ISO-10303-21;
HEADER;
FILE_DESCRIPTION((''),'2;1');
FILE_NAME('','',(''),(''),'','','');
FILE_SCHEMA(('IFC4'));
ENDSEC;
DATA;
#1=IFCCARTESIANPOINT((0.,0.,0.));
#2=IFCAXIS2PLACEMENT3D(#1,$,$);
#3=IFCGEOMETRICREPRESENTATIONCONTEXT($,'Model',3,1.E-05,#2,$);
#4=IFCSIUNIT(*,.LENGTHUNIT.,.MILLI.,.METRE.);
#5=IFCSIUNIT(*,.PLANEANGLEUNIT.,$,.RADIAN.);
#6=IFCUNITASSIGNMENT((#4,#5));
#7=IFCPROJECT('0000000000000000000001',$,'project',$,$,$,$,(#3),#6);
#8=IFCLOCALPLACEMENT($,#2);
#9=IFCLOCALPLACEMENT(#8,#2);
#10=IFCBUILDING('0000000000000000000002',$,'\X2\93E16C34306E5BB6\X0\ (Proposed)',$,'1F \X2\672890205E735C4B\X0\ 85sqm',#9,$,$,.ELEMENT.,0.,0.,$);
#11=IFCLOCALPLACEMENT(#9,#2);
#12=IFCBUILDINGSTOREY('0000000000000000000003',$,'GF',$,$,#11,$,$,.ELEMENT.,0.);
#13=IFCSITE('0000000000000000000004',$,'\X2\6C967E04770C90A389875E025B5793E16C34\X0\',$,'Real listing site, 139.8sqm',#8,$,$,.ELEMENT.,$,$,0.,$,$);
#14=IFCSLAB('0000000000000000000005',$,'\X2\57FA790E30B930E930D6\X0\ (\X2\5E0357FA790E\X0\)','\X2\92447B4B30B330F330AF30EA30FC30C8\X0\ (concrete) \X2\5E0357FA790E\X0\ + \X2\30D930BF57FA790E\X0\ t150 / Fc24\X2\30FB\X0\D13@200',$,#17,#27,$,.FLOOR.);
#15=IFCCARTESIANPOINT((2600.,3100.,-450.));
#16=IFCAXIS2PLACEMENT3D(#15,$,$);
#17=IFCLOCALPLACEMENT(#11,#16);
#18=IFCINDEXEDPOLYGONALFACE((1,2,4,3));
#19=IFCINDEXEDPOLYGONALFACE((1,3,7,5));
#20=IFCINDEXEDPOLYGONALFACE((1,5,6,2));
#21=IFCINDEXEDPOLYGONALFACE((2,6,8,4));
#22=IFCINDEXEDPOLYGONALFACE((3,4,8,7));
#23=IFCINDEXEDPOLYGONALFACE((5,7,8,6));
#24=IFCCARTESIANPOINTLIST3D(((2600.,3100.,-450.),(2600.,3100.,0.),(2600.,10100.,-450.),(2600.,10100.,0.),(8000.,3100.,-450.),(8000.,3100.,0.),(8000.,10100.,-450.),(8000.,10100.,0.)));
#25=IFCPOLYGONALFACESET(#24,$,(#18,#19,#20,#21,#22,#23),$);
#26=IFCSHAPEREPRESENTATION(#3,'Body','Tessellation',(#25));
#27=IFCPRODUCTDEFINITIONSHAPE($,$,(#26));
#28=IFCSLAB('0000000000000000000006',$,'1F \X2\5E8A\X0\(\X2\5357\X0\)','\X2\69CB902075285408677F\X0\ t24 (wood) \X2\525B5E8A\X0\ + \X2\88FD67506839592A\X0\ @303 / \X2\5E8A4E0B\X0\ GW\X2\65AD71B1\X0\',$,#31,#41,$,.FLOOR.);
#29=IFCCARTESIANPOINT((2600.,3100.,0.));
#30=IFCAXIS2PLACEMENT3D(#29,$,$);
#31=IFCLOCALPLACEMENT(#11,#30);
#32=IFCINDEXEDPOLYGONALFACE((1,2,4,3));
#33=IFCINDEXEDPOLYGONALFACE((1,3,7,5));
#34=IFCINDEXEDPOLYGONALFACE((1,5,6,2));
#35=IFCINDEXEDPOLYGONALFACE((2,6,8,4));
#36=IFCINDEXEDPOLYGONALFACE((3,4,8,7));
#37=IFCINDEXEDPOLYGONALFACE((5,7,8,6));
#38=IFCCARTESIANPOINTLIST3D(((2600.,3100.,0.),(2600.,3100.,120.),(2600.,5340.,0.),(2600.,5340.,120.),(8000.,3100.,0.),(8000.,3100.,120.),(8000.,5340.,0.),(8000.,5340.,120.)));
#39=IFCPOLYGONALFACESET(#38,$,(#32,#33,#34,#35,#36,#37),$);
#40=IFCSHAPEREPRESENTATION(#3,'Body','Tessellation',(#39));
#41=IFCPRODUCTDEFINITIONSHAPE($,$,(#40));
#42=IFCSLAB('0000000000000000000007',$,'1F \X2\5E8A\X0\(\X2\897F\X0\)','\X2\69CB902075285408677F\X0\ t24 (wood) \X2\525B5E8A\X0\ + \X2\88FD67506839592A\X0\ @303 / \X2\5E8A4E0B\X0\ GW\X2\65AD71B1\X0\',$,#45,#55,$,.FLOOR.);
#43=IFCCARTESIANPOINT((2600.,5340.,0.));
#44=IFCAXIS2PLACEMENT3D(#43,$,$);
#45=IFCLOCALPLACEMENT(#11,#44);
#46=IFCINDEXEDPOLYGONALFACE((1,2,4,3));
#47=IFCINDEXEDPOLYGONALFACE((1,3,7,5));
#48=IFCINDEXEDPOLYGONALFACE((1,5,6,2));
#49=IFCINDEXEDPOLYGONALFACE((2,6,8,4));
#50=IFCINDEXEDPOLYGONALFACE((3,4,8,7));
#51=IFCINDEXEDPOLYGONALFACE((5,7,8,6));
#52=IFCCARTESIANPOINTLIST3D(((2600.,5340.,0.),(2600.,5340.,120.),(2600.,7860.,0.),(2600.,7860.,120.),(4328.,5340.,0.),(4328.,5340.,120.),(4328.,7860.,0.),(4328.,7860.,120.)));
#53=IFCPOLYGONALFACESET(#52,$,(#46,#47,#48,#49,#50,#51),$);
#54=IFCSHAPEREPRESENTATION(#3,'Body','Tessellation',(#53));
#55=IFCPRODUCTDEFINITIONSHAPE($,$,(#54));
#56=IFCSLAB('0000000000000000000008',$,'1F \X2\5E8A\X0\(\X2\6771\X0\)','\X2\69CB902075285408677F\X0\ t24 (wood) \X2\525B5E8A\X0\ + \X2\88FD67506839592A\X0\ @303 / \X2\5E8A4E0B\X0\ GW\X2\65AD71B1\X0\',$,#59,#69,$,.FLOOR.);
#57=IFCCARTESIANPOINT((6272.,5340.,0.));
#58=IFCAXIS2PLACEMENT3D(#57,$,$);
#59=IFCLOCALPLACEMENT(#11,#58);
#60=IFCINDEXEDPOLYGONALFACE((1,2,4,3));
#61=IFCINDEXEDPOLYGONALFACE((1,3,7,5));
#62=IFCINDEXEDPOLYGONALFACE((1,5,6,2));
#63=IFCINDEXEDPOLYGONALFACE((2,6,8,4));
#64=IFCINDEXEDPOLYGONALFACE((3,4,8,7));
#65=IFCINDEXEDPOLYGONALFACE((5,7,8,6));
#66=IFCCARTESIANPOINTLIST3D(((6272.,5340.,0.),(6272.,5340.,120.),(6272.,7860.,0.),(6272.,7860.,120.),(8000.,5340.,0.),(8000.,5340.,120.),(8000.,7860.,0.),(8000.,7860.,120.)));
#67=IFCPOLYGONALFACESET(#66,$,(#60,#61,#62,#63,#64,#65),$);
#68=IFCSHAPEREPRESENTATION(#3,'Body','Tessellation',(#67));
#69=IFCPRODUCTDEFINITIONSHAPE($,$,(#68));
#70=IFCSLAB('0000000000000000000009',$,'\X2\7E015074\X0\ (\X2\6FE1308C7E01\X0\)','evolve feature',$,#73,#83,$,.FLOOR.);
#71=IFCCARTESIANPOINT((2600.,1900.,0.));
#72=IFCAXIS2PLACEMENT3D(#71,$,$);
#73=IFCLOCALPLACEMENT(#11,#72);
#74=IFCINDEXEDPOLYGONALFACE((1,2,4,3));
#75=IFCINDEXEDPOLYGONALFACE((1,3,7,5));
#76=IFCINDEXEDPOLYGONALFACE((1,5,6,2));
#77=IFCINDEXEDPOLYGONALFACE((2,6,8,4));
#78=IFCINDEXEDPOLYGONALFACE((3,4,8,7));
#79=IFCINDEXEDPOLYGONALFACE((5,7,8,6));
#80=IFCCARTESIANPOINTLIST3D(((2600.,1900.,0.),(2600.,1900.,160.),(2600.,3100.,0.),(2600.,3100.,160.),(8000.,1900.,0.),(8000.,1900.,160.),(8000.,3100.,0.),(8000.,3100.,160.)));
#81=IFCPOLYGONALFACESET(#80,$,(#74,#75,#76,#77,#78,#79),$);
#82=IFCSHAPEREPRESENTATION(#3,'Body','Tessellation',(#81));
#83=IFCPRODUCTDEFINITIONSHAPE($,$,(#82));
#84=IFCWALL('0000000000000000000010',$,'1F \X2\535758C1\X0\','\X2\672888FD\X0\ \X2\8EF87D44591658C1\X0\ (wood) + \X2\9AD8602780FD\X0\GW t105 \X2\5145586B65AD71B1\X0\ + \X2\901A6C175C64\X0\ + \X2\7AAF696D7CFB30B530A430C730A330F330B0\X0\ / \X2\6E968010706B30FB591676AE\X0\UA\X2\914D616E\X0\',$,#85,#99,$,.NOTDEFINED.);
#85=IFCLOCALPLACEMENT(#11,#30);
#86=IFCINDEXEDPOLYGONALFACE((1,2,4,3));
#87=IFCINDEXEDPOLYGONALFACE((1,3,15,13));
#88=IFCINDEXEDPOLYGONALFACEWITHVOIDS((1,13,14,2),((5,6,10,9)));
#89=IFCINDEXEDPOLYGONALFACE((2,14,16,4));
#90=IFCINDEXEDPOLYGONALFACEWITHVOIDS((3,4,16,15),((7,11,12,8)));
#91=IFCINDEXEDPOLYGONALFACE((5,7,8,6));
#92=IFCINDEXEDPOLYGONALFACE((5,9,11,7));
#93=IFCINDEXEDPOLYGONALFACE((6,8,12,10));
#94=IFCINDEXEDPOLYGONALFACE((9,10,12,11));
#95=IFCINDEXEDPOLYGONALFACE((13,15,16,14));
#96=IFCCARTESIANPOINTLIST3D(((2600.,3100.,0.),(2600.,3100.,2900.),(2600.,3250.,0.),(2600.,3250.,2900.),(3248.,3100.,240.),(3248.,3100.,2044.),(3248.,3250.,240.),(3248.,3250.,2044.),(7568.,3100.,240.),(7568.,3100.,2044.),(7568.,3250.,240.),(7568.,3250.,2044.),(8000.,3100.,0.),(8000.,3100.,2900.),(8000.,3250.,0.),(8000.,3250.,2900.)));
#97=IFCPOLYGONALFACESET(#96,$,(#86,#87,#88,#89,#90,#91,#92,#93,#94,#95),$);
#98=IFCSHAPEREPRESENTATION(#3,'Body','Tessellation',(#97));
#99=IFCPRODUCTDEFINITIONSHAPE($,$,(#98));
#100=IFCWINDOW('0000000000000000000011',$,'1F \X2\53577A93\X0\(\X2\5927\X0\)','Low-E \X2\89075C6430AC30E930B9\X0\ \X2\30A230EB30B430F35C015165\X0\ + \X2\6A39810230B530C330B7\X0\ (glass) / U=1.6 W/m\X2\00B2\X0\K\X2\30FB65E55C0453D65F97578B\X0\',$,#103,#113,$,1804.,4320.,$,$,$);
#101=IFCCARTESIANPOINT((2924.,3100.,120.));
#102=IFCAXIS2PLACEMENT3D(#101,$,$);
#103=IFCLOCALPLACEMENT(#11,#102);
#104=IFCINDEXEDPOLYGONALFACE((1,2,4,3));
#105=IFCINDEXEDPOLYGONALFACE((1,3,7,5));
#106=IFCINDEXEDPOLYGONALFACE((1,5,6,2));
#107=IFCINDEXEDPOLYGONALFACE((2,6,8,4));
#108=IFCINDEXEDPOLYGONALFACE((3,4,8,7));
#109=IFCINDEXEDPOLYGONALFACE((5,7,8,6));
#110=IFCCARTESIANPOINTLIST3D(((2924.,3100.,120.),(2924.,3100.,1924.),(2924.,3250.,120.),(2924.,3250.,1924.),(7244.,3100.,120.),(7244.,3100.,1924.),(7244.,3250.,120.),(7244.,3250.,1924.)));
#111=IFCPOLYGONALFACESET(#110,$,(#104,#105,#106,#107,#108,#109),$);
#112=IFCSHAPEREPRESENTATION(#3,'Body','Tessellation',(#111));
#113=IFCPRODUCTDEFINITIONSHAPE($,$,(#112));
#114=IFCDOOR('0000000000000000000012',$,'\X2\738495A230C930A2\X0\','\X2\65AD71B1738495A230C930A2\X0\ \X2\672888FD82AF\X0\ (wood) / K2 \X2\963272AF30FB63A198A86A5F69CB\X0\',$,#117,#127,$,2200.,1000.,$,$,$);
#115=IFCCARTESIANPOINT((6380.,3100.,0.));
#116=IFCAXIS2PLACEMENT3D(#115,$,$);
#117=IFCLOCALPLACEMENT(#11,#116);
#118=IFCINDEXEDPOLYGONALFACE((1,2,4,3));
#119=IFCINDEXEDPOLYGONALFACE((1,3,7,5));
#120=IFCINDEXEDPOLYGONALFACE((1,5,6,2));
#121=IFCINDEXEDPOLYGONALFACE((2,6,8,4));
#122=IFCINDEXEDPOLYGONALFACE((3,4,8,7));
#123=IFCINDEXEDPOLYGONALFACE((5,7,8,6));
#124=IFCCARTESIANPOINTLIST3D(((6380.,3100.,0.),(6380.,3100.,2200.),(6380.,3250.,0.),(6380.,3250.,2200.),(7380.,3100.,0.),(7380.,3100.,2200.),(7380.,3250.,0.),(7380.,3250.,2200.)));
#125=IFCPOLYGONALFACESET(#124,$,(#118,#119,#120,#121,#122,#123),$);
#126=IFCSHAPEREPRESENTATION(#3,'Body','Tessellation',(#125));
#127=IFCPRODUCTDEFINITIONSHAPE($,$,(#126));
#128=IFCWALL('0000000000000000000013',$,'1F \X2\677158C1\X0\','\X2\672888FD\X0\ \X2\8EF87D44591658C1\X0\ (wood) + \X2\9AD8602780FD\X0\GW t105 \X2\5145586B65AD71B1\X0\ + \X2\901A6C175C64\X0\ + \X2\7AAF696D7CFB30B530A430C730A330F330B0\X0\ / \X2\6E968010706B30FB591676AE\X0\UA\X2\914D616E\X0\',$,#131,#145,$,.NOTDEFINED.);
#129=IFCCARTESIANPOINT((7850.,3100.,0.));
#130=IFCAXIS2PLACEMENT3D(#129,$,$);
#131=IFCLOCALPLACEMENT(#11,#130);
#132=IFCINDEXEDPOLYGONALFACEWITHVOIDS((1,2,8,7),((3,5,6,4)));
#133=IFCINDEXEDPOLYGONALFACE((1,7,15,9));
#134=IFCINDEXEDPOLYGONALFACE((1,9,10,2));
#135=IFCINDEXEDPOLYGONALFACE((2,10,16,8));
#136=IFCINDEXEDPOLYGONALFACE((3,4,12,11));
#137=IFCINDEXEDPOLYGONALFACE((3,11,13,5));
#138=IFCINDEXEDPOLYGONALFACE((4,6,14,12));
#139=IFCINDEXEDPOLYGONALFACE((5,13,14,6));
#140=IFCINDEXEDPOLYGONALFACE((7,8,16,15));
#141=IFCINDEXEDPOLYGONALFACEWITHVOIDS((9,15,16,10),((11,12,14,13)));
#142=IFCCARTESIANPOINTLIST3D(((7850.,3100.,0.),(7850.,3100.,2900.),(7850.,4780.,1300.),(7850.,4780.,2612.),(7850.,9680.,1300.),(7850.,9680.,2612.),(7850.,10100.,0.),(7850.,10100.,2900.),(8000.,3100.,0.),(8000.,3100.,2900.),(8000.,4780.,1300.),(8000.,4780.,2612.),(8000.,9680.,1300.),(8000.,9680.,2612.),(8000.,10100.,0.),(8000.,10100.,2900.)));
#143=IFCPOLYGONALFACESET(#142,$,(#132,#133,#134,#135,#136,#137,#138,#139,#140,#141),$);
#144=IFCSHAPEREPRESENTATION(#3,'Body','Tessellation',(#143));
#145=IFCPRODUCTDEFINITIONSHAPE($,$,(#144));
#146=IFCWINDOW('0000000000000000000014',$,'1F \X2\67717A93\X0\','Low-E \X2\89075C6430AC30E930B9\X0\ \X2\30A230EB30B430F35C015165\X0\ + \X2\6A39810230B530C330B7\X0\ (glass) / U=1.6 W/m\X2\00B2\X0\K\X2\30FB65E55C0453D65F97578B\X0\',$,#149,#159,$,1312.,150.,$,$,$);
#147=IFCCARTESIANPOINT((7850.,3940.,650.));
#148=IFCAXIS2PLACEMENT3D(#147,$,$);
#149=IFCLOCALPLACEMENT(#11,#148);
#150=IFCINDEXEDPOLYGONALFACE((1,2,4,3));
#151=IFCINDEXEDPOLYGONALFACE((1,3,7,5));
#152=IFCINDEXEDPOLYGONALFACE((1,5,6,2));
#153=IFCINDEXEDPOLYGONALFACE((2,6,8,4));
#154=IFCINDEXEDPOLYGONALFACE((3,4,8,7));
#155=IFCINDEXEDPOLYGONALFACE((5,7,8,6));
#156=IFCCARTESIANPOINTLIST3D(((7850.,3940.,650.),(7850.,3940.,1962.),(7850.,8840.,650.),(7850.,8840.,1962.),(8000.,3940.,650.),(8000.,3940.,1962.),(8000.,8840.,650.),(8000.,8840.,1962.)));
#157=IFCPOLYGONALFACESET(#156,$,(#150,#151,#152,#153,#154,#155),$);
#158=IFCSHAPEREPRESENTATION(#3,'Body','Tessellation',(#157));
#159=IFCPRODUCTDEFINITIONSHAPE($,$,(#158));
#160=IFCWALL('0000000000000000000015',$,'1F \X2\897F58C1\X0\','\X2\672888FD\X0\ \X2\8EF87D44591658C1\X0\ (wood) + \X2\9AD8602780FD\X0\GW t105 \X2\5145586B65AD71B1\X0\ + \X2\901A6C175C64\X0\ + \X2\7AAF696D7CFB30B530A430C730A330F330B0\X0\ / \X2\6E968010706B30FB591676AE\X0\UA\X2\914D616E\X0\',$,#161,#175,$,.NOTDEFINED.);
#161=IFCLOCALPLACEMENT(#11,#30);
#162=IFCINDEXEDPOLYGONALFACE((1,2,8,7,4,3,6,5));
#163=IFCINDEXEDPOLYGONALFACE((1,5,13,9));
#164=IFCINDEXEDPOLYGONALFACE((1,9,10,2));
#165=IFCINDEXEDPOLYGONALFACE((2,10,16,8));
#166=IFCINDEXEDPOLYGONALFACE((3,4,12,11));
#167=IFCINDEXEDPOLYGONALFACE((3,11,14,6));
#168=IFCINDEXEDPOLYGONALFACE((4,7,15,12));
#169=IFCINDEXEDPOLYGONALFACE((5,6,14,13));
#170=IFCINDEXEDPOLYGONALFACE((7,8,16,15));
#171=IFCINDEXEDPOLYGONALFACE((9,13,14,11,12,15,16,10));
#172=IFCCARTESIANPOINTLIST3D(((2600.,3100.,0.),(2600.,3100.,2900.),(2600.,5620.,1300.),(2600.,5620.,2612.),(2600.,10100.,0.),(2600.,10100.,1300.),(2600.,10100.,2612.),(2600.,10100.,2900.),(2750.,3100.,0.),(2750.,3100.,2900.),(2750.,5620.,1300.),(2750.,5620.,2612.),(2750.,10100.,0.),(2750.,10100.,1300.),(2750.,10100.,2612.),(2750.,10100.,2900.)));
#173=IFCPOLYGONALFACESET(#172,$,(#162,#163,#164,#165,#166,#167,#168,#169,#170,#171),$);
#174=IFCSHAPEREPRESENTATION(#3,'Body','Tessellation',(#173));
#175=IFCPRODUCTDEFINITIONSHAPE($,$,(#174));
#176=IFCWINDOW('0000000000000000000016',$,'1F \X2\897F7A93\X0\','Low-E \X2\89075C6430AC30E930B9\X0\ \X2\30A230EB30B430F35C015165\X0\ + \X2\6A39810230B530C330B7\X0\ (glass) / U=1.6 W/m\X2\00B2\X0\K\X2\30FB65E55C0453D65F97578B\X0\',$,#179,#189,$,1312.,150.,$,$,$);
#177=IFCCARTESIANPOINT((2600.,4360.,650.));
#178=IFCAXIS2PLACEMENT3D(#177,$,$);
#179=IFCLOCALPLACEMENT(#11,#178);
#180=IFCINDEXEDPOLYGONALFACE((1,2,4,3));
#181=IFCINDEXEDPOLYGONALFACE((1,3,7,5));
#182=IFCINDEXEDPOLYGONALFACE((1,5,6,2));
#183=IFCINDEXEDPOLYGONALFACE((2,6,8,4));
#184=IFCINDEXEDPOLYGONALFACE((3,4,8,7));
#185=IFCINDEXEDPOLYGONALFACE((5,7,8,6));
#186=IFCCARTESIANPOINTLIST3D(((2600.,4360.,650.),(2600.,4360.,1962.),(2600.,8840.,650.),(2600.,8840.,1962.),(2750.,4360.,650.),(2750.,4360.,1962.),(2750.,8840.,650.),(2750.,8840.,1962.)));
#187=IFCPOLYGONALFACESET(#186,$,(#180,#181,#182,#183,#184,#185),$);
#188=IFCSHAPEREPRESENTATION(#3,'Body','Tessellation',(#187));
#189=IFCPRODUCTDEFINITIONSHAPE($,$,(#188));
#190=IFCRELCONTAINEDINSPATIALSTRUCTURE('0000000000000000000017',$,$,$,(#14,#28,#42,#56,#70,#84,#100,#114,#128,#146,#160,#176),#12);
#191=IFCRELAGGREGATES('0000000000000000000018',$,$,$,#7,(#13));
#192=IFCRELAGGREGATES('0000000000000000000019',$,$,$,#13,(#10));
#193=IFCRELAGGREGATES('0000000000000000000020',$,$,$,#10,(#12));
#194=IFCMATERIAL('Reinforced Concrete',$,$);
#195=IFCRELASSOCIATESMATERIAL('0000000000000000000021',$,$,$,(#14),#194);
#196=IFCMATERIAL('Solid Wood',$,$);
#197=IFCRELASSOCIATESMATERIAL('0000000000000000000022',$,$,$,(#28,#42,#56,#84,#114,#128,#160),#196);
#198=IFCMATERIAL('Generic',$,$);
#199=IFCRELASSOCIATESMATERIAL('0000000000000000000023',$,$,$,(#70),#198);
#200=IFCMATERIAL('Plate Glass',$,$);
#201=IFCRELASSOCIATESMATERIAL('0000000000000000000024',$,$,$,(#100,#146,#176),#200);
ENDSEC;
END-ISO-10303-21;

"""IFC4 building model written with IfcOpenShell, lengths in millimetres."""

from ifc_helpers import new_model, si_unit, frame, frame_2d, origin, place, context, project, spatial, rectangle, extrude, material, element, fill, save


model = new_model("IFC4")

# Units and contexts
model_context = context("Model", 3, precision=1e-05, world=origin())
ifc_project = project(units=[si_unit("LENGTHUNIT", "METRE", prefix="MILLI"), si_unit("PLANEANGLEUNIT", "RADIAN")], contexts=[model_context])

# Site, building, storey
site_placement = place(None, origin())
site = spatial("IfcSite", under=ifc_project, at=site_placement, Name="沖縄県那覇市字鏡水", ObjectType="Real listing site, 139.8sqm", CompositionType="ELEMENT", RefElevation=0.0)
building_placement = place(site_placement, origin())
building = spatial("IfcBuilding", under=site, at=building_placement, Name="鏡水の家 (Proposed)", ObjectType="1F 木造平屋 85sqm", CompositionType="ELEMENT", ElevationOfRefHeight=0.0, ElevationOfTerrain=0.0)
storey_placement = place(building_placement, origin())
storey = spatial("IfcBuildingStorey", under=building, at=storey_placement, Name="GF", CompositionType="ELEMENT", Elevation=0.0)

# Slabs
ifc_material_1 = material(Name="Reinforced Concrete")
slab_1_placement = place(storey_placement, frame((2600.0, 3100.0, -450.0)))
element("IfcSlab", 1, at=slab_1_placement, inside=storey, material=ifc_material_1, Name="基礎スラブ (布基礎)", Description="鉄筋コンクリート (concrete) 布基礎 + ベタ基礎 t150 / Fc24・D13@200", PredefinedType="FLOOR", context=model_context, shape_type="SweptSolid", body=[
    extrude(rectangle(XDim=5400.0, YDim=7000.0, at=frame_2d((2700.0, 3500.0))), frame((2600.0, 3100.0, -450.0)), (0.0, 0.0, 1.0), 450.0),
])
ifc_material_2 = material(Name="Solid Wood")
slab_2_placement = place(storey_placement, frame((2600.0, 3100.0, 0.0)))
element("IfcSlab", 2, at=slab_2_placement, inside=storey, material=ifc_material_2, Name="1F 床(南)", Description="構造用合板 t24 (wood) 剛床 + 製材根太 @303 / 床下 GW断熱", PredefinedType="FLOOR", context=model_context, shape_type="SweptSolid", body=[
    extrude(rectangle(XDim=5400.0, YDim=2240.0, at=frame_2d((2700.0, 1120.0))), frame((2600.0, 3100.0, 0.0)), (0.0, 0.0, 1.0), 120.0),
])
slab_3_placement = place(storey_placement, frame((2600.0, 5340.0, 0.0)))
element("IfcSlab", 3, at=slab_3_placement, inside=storey, material=ifc_material_2, Name="1F 床(西)", Description="構造用合板 t24 (wood) 剛床 + 製材根太 @303 / 床下 GW断熱", PredefinedType="FLOOR", context=model_context, shape_type="SweptSolid", body=[
    extrude(rectangle(XDim=1728.0, YDim=2520.0, at=frame_2d((864.0, 1260.0))), frame((2600.0, 5340.0, 0.0)), (0.0, 0.0, 1.0), 120.0),
])
slab_4_placement = place(storey_placement, frame((6272.0, 5340.0, 0.0)))
element("IfcSlab", 4, at=slab_4_placement, inside=storey, material=ifc_material_2, Name="1F 床(東)", Description="構造用合板 t24 (wood) 剛床 + 製材根太 @303 / 床下 GW断熱", PredefinedType="FLOOR", context=model_context, shape_type="SweptSolid", body=[
    extrude(rectangle(XDim=1728.0, YDim=2520.0, at=frame_2d((864.0, 1260.0))), frame((6272.0, 5340.0, 0.0)), (0.0, 0.0, 1.0), 120.0),
])
ifc_material_3 = material(Name="Generic")
slab_5_placement = place(storey_placement, frame((2600.0, 1900.0, 0.0)))
element("IfcSlab", 5, at=slab_5_placement, inside=storey, material=ifc_material_3, Name="縁側 (濡れ縁)", Description="evolve feature", PredefinedType="FLOOR", context=model_context, shape_type="SweptSolid", body=[
    extrude(rectangle(XDim=5400.0, YDim=1200.0, at=frame_2d((2700.0, 600.0))), frame((2600.0, 1900.0, 0.0)), (0.0, 0.0, 1.0), 160.0),
])

# Wall, openings, window, door
wall_1_placement = place(storey_placement, frame((2600.0, 3100.0, 0.0)))
wall_1 = element("IfcWall", 6, at=wall_1_placement, inside=storey, material=ifc_material_2, Name="1F 南壁", Description="木製 軸組外壁 (wood) + 高性能GW t105 充填断熱 + 通気層 + 窯業系サイディング / 準耐火・外皮UA配慮", PredefinedType="NOTDEFINED", context=model_context, shape_type="SweptSolid", body=[
    extrude(rectangle(XDim=5400.0, YDim=150.0, at=frame_2d((2700.0, 75.0))), frame((2600.0, 3100.0, 0.0)), (0.0, 0.0, 1.0), 2900.0),
])
opening_1_placement = place(storey_placement, frame((2924.0, 3100.0, 120.0)))
opening_1 = element("IfcOpeningElement", 7, at=opening_1_placement, cuts=wall_1, PredefinedType="NOTDEFINED", context=model_context, shape_type="SweptSolid", body=[
    extrude(rectangle(XDim=4320.0, YDim=150.0, at=frame_2d((2160.0, 75.0))), frame((2924.0, 3100.0, 120.0)), (0.0, 0.0, 1.0), 1804.0),
])
opening_2_placement = place(storey_placement, frame((6380.0, 3100.0, 0.0)))
opening_2 = element("IfcOpeningElement", 8, at=opening_2_placement, cuts=wall_1, PredefinedType="NOTDEFINED", context=model_context, shape_type="SweptSolid", body=[
    extrude(rectangle(XDim=1000.0, YDim=150.0, at=frame_2d((500.0, 75.0))), frame((6380.0, 3100.0, 0.0)), (0.0, 0.0, 1.0), 2200.0),
])
ifc_material_4 = material(Name="Plate Glass")
window_1_placement = place(storey_placement, frame((2924.0, 3100.0, 120.0)))
window_1 = element("IfcWindow", 9, at=window_1_placement, inside=storey, material=ifc_material_4, Name="1F 南窓(大)", Description="Low-E 複層ガラス アルゴン封入 + 樹脂サッシ (glass) / U=1.6 W/m²K・日射取得型", OverallHeight=1804.0, OverallWidth=4320.0, context=model_context, shape_type="SweptSolid", body=[
    extrude(rectangle(XDim=4320.0, YDim=150.0, at=frame_2d((2160.0, 75.0))), frame((2924.0, 3100.0, 120.0)), (0.0, 0.0, 1.0), 1804.0),
])
fill(opening_1, window_1)
door_placement = place(storey_placement, frame((6380.0, 3100.0, 0.0)))
door = element("IfcDoor", 10, at=door_placement, inside=storey, material=ifc_material_2, Name="玄関ドア", Description="断熱玄関ドア 木製芯 (wood) / K2 防犯・採風機構", OverallHeight=2200.0, OverallWidth=1000.0, context=model_context, shape_type="SweptSolid", body=[
    extrude(rectangle(XDim=1000.0, YDim=150.0, at=frame_2d((500.0, 75.0))), frame((6380.0, 3100.0, 0.0)), (0.0, 0.0, 1.0), 2200.0),
])
fill(opening_2, door)

# Walls, openings, windows
wall_2_placement = place(storey_placement, frame((7850.0, 3100.0, 0.0)))
wall_2 = element("IfcWall", 11, at=wall_2_placement, inside=storey, material=ifc_material_2, Name="1F 東壁", Description="木製 軸組外壁 (wood) + 高性能GW t105 充填断熱 + 通気層 + 窯業系サイディング / 準耐火・外皮UA配慮", PredefinedType="NOTDEFINED", context=model_context, shape_type="SweptSolid", body=[
    extrude(rectangle(XDim=150.0, YDim=7000.0, at=frame_2d((75.0, 3500.0))), frame((7850.0, 3100.0, 0.0)), (0.0, 0.0, 1.0), 2900.0),
])
opening_3_placement = place(storey_placement, frame((7850.0, 3940.0, 650.0)))
opening_3 = element("IfcOpeningElement", 12, at=opening_3_placement, cuts=wall_2, PredefinedType="NOTDEFINED", context=model_context, shape_type="SweptSolid", body=[
    extrude(rectangle(XDim=150.0, YDim=4900.0, at=frame_2d((75.0, 2450.0))), frame((7850.0, 3940.0, 650.0)), (0.0, 0.0, 1.0), 1312.0),
])
window_2_placement = place(storey_placement, frame((7850.0, 3940.0, 650.0)))
window_2 = element("IfcWindow", 13, at=window_2_placement, inside=storey, material=ifc_material_4, Name="1F 東窓", Description="Low-E 複層ガラス アルゴン封入 + 樹脂サッシ (glass) / U=1.6 W/m²K・日射取得型", OverallHeight=1312.0, OverallWidth=150.0, context=model_context, shape_type="SweptSolid", body=[
    extrude(rectangle(XDim=150.0, YDim=4900.0, at=frame_2d((75.0, 2450.0))), frame((7850.0, 3940.0, 650.0)), (0.0, 0.0, 1.0), 1312.0),
])
fill(opening_3, window_2)
wall_3_placement = place(storey_placement, frame((2600.0, 3100.0, 0.0)))
wall_3 = element("IfcWall", 14, at=wall_3_placement, inside=storey, material=ifc_material_2, Name="1F 西壁", Description="木製 軸組外壁 (wood) + 高性能GW t105 充填断熱 + 通気層 + 窯業系サイディング / 準耐火・外皮UA配慮", PredefinedType="NOTDEFINED", context=model_context, shape_type="SweptSolid", body=[
    extrude(rectangle(XDim=150.0, YDim=7000.0, at=frame_2d((75.0, 3500.0))), frame((2600.0, 3100.0, 0.0)), (0.0, 0.0, 1.0), 2900.0),
])
opening_4_placement = place(storey_placement, frame((2600.0, 4360.0, 650.0)))
opening_4 = element("IfcOpeningElement", 15, at=opening_4_placement, cuts=wall_3, PredefinedType="NOTDEFINED", context=model_context, shape_type="SweptSolid", body=[
    extrude(rectangle(XDim=150.0, YDim=4480.0, at=frame_2d((75.0, 2240.0))), frame((2600.0, 4360.0, 650.0)), (0.0, 0.0, 1.0), 1312.0),
])
window_3_placement = place(storey_placement, frame((2600.0, 4360.0, 650.0)))
window_3 = element("IfcWindow", 16, at=window_3_placement, inside=storey, material=ifc_material_4, Name="1F 西窓", Description="Low-E 複層ガラス アルゴン封入 + 樹脂サッシ (glass) / U=1.6 W/m²K・日射取得型", OverallHeight=1312.0, OverallWidth=150.0, context=model_context, shape_type="SweptSolid", body=[
    extrude(rectangle(XDim=150.0, YDim=4480.0, at=frame_2d((75.0, 2240.0))), frame((2600.0, 4360.0, 650.0)), (0.0, 0.0, 1.0), 1312.0),
])
fill(opening_4, window_3)

save(model, "model.ifc")
